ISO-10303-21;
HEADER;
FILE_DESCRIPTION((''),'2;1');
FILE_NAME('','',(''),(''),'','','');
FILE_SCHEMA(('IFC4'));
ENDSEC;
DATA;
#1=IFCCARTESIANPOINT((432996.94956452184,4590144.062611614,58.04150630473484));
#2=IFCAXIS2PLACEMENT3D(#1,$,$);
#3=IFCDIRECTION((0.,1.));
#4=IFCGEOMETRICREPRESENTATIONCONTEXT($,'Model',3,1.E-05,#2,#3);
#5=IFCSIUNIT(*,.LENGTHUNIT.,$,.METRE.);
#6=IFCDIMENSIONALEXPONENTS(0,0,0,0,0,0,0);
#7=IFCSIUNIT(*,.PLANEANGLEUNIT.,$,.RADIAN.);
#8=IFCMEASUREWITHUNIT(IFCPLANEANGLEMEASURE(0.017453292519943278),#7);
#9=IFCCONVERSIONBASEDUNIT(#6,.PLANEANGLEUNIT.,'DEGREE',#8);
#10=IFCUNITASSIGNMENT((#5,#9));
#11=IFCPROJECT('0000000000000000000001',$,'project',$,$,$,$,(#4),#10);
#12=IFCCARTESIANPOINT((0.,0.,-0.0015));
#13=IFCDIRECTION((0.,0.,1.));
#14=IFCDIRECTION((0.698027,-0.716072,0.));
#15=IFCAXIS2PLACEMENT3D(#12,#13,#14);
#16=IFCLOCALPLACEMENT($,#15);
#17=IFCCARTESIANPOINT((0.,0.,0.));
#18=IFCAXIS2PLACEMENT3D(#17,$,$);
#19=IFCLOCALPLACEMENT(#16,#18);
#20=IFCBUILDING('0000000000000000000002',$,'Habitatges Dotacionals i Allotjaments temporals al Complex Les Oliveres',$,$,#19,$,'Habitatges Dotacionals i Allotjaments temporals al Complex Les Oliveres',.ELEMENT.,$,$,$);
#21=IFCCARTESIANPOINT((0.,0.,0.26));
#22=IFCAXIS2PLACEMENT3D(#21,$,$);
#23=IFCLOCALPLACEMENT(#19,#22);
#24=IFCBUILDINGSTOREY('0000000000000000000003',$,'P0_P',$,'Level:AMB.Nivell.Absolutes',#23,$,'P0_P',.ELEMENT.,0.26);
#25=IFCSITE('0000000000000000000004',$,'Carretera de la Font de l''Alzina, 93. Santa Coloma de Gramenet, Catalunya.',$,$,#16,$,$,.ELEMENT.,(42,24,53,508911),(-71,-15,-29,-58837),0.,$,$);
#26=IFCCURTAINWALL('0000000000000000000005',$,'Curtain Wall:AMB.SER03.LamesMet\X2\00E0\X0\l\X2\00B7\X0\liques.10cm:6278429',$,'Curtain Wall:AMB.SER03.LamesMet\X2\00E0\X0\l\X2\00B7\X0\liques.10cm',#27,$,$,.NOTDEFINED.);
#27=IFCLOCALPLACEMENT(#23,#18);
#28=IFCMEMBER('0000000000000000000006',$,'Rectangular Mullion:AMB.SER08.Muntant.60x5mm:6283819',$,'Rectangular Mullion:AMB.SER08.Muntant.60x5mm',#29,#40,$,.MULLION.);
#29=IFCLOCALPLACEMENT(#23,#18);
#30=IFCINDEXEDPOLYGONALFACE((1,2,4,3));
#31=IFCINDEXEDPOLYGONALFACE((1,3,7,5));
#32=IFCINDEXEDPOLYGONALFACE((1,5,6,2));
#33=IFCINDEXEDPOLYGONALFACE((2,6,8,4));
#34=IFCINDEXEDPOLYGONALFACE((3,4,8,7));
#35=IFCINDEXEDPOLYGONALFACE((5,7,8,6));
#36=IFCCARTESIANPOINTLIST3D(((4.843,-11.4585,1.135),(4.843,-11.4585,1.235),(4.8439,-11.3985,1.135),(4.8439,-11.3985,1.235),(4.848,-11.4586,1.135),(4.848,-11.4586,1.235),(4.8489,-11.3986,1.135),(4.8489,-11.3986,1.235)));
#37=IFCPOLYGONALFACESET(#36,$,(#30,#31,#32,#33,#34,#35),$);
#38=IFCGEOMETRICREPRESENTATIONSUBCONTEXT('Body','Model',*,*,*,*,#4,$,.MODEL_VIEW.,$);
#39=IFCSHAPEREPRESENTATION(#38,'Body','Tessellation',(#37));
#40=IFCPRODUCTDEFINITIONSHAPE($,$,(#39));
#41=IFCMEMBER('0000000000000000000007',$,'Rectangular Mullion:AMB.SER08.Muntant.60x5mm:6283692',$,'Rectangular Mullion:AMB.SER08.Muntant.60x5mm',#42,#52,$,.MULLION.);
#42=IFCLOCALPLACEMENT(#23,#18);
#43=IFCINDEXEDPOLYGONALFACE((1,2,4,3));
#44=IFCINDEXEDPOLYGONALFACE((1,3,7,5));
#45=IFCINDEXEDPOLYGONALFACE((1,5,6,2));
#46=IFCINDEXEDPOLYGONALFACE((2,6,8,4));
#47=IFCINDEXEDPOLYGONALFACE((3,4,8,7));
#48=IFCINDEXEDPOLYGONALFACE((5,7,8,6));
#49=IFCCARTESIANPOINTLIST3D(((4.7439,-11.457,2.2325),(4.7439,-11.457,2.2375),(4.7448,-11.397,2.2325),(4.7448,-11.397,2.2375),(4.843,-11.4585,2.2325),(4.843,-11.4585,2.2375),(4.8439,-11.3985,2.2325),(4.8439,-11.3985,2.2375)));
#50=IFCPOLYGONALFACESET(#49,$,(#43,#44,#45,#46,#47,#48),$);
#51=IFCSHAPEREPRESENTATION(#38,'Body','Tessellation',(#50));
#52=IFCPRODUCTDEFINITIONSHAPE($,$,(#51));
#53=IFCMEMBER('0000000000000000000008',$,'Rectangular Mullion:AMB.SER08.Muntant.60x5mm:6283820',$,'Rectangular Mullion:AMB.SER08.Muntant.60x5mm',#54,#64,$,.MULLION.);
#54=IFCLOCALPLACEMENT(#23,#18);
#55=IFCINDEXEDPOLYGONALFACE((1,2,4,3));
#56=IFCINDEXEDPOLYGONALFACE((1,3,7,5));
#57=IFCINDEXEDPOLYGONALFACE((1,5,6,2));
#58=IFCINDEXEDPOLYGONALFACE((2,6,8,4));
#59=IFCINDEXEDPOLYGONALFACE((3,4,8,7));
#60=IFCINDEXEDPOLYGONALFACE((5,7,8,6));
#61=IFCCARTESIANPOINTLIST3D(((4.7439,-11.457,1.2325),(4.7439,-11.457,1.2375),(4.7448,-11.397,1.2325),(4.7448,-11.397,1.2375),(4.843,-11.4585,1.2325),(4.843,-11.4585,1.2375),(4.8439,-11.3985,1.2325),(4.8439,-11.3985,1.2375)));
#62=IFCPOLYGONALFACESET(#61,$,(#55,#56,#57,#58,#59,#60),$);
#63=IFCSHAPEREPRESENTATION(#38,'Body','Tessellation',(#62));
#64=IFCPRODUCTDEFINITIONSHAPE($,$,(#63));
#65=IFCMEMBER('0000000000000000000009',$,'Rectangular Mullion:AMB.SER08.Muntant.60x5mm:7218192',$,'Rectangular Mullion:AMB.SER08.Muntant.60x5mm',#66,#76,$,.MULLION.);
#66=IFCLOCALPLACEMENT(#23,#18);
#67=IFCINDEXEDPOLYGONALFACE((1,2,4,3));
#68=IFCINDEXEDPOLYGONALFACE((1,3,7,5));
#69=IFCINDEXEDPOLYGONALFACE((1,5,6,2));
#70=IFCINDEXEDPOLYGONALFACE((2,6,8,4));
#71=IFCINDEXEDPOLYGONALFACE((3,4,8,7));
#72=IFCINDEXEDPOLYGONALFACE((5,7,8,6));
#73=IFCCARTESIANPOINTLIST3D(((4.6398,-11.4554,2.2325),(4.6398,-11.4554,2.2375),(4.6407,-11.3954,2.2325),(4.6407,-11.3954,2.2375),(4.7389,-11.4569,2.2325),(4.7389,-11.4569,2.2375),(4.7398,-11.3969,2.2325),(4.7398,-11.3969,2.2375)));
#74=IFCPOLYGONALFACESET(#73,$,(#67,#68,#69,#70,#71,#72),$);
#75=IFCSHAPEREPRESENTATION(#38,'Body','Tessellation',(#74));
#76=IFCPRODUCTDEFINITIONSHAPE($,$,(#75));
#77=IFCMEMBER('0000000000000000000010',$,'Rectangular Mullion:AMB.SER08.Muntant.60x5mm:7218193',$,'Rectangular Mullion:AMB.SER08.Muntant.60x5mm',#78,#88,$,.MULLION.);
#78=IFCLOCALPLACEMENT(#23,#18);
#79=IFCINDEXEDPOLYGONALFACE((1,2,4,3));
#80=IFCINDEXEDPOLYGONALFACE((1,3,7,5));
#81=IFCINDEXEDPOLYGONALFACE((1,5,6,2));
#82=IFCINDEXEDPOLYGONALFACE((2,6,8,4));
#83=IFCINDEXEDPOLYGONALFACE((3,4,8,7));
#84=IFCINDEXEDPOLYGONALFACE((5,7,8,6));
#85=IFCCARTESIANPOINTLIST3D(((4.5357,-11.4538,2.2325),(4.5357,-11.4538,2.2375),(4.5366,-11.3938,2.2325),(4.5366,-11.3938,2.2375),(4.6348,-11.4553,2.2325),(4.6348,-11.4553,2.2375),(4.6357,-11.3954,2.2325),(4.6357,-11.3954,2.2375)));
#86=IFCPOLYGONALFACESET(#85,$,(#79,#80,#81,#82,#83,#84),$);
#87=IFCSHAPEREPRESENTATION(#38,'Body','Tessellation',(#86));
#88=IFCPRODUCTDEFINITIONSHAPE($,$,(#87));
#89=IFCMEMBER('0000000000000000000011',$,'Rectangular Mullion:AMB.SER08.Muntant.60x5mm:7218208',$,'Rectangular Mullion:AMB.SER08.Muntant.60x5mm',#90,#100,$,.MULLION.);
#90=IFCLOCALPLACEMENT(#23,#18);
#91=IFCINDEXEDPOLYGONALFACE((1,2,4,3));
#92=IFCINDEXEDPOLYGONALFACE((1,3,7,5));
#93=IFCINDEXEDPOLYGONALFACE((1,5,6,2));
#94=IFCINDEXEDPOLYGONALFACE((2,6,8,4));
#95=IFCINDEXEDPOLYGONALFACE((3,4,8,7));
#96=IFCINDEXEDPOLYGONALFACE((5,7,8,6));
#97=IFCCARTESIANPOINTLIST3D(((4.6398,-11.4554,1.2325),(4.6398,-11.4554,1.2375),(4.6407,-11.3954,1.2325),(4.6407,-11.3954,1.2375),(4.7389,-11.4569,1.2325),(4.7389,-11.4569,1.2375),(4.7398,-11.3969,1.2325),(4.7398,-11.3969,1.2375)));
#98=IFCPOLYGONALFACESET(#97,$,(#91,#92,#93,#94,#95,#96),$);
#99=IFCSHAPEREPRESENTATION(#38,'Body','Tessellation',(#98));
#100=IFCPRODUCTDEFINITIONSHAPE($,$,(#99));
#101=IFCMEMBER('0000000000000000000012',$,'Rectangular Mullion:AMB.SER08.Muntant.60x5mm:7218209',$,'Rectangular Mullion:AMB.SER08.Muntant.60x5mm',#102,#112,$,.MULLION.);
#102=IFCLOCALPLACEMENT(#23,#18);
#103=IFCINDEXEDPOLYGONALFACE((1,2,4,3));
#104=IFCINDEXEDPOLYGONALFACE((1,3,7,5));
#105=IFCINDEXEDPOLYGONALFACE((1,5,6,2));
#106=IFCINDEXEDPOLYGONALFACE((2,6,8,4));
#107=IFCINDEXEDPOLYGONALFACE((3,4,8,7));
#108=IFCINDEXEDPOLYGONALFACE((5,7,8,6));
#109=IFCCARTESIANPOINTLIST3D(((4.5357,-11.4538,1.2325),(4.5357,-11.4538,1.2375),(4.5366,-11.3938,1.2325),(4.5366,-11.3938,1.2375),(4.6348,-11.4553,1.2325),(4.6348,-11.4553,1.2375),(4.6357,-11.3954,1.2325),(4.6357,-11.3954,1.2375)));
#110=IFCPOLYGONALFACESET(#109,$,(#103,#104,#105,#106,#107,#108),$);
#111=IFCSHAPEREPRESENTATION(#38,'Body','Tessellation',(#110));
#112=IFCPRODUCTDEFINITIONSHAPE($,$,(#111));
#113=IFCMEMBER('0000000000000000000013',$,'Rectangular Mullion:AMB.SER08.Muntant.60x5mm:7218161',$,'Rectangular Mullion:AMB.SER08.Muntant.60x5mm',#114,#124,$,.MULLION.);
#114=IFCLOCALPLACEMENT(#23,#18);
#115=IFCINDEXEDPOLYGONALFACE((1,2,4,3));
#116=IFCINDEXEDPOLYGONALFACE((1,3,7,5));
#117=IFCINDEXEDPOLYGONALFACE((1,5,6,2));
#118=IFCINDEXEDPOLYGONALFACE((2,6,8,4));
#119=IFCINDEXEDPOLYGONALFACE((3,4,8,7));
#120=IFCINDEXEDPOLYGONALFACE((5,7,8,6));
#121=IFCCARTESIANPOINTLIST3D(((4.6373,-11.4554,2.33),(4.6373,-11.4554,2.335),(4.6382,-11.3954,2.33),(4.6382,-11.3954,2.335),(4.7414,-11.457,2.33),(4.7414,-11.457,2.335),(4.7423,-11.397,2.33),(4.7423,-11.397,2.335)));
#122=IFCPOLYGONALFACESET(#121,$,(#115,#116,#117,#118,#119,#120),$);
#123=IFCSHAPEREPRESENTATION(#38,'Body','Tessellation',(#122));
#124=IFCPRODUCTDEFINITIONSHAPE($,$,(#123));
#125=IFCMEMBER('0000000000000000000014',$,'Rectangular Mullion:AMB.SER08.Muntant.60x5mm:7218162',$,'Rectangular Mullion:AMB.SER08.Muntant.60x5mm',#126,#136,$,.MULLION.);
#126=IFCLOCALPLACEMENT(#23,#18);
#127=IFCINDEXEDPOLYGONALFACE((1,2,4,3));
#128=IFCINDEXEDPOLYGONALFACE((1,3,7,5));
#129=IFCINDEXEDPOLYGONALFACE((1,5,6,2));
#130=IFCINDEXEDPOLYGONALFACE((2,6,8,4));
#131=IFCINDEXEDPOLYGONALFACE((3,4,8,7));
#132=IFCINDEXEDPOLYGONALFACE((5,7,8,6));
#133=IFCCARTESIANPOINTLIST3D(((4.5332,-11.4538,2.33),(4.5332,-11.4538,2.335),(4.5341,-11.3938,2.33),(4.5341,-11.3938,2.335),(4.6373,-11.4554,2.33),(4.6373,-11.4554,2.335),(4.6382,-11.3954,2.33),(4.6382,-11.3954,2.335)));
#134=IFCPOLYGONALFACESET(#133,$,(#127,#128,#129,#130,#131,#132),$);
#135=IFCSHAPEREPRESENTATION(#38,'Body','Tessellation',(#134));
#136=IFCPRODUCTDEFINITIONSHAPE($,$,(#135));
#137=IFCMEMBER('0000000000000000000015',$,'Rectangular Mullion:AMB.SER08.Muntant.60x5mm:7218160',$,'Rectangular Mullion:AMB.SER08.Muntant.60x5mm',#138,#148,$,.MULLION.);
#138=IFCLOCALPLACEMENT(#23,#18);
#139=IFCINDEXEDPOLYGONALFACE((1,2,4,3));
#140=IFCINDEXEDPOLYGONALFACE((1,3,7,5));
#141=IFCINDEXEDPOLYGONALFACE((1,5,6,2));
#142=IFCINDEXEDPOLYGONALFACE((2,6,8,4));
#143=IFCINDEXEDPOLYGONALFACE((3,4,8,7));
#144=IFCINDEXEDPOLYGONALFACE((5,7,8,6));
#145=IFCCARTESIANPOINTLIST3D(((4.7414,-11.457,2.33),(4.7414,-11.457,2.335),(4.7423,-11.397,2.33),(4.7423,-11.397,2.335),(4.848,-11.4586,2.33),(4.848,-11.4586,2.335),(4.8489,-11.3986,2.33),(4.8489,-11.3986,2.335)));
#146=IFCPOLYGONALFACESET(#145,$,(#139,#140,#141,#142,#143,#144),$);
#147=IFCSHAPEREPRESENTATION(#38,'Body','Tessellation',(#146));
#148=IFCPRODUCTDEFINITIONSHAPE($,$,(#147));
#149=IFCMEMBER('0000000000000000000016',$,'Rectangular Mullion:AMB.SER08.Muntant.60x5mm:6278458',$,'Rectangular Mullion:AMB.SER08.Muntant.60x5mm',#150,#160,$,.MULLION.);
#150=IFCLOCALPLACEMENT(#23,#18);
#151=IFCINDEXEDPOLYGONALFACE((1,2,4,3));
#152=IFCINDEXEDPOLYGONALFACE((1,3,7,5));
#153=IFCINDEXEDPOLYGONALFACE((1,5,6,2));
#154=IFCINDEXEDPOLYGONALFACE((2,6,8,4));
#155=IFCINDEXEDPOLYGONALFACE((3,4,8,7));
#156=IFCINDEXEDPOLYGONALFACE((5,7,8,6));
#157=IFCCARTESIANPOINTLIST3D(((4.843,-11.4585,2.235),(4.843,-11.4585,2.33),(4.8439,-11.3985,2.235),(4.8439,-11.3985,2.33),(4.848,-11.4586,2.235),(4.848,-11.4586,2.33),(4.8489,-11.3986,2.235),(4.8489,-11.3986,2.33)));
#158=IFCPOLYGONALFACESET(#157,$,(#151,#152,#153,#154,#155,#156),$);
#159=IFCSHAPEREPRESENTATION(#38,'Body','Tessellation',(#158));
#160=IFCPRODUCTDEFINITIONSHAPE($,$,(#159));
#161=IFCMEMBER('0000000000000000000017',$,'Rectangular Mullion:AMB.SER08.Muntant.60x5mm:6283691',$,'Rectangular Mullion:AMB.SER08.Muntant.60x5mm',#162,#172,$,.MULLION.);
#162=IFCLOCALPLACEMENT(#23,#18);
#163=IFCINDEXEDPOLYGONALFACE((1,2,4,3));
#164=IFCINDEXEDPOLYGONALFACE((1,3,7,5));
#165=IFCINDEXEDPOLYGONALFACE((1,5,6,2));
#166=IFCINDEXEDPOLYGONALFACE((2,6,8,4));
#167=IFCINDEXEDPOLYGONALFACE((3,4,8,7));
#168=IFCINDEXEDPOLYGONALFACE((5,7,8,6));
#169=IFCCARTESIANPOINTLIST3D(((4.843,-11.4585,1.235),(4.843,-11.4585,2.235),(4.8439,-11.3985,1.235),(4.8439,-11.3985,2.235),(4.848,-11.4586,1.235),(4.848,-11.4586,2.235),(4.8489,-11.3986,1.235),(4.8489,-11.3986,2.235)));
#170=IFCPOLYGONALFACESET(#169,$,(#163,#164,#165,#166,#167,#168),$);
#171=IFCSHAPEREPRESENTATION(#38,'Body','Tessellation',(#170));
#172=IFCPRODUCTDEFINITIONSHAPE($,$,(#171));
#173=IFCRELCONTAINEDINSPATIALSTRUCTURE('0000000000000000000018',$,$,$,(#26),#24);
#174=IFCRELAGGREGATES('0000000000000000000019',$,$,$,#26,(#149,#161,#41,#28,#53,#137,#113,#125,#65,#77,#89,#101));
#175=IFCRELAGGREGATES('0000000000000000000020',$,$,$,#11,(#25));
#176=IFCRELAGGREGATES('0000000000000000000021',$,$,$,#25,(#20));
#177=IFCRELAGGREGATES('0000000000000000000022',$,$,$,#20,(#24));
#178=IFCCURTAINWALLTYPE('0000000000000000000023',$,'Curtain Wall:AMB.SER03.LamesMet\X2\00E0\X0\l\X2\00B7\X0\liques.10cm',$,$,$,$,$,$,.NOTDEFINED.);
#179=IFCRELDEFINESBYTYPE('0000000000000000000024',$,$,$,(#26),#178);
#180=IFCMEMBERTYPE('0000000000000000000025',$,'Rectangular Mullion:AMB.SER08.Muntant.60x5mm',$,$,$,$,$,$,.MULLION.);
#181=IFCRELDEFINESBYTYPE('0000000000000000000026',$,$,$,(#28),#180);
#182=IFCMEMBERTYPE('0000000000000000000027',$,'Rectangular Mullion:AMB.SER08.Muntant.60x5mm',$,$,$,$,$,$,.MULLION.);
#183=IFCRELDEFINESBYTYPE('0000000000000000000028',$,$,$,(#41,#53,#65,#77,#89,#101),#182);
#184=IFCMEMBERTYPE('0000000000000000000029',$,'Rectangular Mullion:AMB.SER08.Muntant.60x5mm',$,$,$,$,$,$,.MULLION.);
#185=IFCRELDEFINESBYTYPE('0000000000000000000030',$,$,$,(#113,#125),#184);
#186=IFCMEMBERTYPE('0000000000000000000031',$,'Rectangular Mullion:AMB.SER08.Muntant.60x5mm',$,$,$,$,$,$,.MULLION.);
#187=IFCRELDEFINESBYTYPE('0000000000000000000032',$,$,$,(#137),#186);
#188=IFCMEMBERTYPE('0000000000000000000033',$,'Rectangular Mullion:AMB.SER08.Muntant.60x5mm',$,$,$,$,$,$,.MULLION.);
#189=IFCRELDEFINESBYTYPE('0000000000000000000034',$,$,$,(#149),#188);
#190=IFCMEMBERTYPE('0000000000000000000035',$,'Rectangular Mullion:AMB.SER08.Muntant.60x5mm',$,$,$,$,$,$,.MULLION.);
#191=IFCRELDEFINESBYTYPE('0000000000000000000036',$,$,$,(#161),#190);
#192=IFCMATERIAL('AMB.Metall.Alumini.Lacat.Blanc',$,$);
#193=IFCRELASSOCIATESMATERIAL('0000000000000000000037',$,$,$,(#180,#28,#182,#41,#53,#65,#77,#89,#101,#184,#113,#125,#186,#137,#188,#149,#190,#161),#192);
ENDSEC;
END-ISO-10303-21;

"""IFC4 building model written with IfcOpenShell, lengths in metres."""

from ifc_helpers import new_model, entity, si_unit, converted_unit, direction, frame, origin, place, context, subcontext, project, spatial, indexed_curve, outline, extrude, source, transform, mapped, material, type_object, type_shapes, element, aggregate, save


model = new_model("IFC4")

# Units and contexts
model_context = context("Model", 3, precision=1e-05, world=frame((432996.94956452184, 4590144.062611614, 58.04150630473484)), true_north=direction((0.0, 1.0)))
body_context = subcontext(model_context, "Body", "Model", "MODEL_VIEW")
ifc_project = project(units=[si_unit("LENGTHUNIT", "METRE"), converted_unit("PLANEANGLEUNIT", "DEGREE", entity("IfcPlaneAngleMeasure", 0.017453292519943278), si_unit("PLANEANGLEUNIT", "RADIAN"), dimensions=[0, 0, 0, 0, 0, 0, 0])], contexts=[model_context])

# Site, building, storey
site_placement = place(None, frame((0.0, 0.0, -0.0015), z_axis=(0.0, 0.0, 1.0), x_axis=(0.698027, -0.716072, 0.0)))
site = spatial("IfcSite", under=ifc_project, at=site_placement, Name="Carretera de la Font de l'Alzina, 93. Santa Coloma de Gramenet, Catalunya.", CompositionType="ELEMENT", RefLatitude=(42, 24, 53, 508911), RefLongitude=(-71, -15, -29, -58837), RefElevation=0.0)
building_placement = place(site_placement, origin())
building = spatial("IfcBuilding", under=site, at=building_placement, Name="Habitatges Dotacionals i Allotjaments temporals al Complex Les Oliveres", LongName="Habitatges Dotacionals i Allotjaments temporals al Complex Les Oliveres", CompositionType="ELEMENT")
storey_placement = place(building_placement, frame((0.0, 0.0, 0.26)))
storey = spatial("IfcBuildingStorey", under=building, at=storey_placement, Name="P0_P", ObjectType="Level:AMB.Nivell.Absolutes", LongName="P0_P", CompositionType="ELEMENT", Elevation=0.26)

# Curtain wall, members
curtain_wall_type_1 = type_object("IfcCurtainWallType", Name="Curtain Wall:AMB.SER03.LamesMetàl·liques.10cm", PredefinedType="NOTDEFINED")
curtain_wall_1_placement = place(storey_placement, frame((0.0, 0.0, -0.26)))
curtain_wall_1 = element("IfcCurtainWall", 1, at=curtain_wall_1_placement, inside=storey, type_object=curtain_wall_type_1, Name="Curtain Wall:AMB.SER03.LamesMetàl·liques.10cm:6278429", ObjectType="Curtain Wall:AMB.SER03.LamesMetàl·liques.10cm", PredefinedType="NOTDEFINED")
ifc_material_1 = material(Name="AMB.Metall.Alumini.Lacat.Blanc")
member_type_1 = type_object("IfcMemberType", Name="Rectangular Mullion:AMB.SER08.Muntant.60x5mm", PredefinedType="MULLION", material=ifc_material_1)
shared_shape_1 = source(origin(), body_context, "Body", "SweptSolid", [
    extrude(outline(indexed_curve([(-0.0025, -0.03), (0.0025, -0.03), (0.0025, 0.03), (-0.0025, 0.03), (-0.0025, -0.03)], self_intersect=False)), frame((-0.0025, 0.03, -0.1), z_axis=(0.0, 0.0, 1.0), x_axis=(-1.0, 0.0, 0.0)), (0.0, 0.0, 1.0), 0.1),
])
type_shapes(member_type_1, [shared_shape_1])
member_1_placement = place(curtain_wall_1_placement, frame((4.848, -11.4586, 1.495), z_axis=(0.0, 0.0, 1.0), x_axis=(0.999883, -0.015319, 0.0)))
member_1 = element("IfcMember", 2, at=member_1_placement, type_object=member_type_1, material=ifc_material_1, Name="Rectangular Mullion:AMB.SER08.Muntant.60x5mm:6283819", ObjectType="Rectangular Mullion:AMB.SER08.Muntant.60x5mm", PredefinedType="MULLION", context=body_context, shape_type="MappedRepresentation", body=[
    mapped(shared_shape_1, transform((0.0, 0.0, 0.0), scale=1.0)),
])
member_type_2 = type_object("IfcMemberType", Name="Rectangular Mullion:AMB.SER08.Muntant.60x5mm", PredefinedType="MULLION", material=ifc_material_1)
shared_shape_2 = source(origin(), body_context, "Body", "SweptSolid", [
    extrude(outline(indexed_curve([(-0.0025, -0.03), (0.0025, -0.03), (0.0025, 0.03), (-0.0025, 0.03), (-0.0025, -0.03)], self_intersect=False)), frame((0.0, 0.03, -0.0991), z_axis=(0.0, 0.0, 1.0), x_axis=(-1.0, 0.0, 0.0)), (0.0, 0.0, 1.0), 0.0991),
])
type_shapes(member_type_2, [shared_shape_2])
member_2_placement = place(curtain_wall_1_placement, frame((4.7439, -11.457, 2.495), z_axis=(-0.999883, 0.015319, 0.0), x_axis=(0.0, 0.0, 1.0)))
member_2 = element("IfcMember", 3, at=member_2_placement, type_object=member_type_2, material=ifc_material_1, Name="Rectangular Mullion:AMB.SER08.Muntant.60x5mm:6283692", ObjectType="Rectangular Mullion:AMB.SER08.Muntant.60x5mm", PredefinedType="MULLION", context=body_context, shape_type="MappedRepresentation", body=[
    mapped(shared_shape_2, transform((0.0, 0.0, 0.0), scale=1.0)),
])
member_3_placement = place(curtain_wall_1_placement, frame((4.7439, -11.457, 1.495), z_axis=(-0.999883, 0.015319, 0.0), x_axis=(0.0, 0.0, 1.0)))
member_3 = element("IfcMember", 4, at=member_3_placement, type_object=member_type_2, material=ifc_material_1, Name="Rectangular Mullion:AMB.SER08.Muntant.60x5mm:6283820", ObjectType="Rectangular Mullion:AMB.SER08.Muntant.60x5mm", PredefinedType="MULLION", context=body_context, shape_type="MappedRepresentation", body=[
    mapped(shared_shape_2, transform((0.0, 0.0, 0.0), scale=1.0)),
])
member_4_placement = place(curtain_wall_1_placement, frame((4.6398, -11.4554, 2.495), z_axis=(-0.999883, 0.015319, 0.0), x_axis=(0.0, 0.0, 1.0)))
member_4 = element("IfcMember", 5, at=member_4_placement, type_object=member_type_2, material=ifc_material_1, Name="Rectangular Mullion:AMB.SER08.Muntant.60x5mm:7218192", ObjectType="Rectangular Mullion:AMB.SER08.Muntant.60x5mm", PredefinedType="MULLION", context=body_context, shape_type="MappedRepresentation", body=[
    mapped(shared_shape_2, transform((0.0, 0.0, 0.0), scale=1.0)),
])
member_5_placement = place(curtain_wall_1_placement, frame((4.5357, -11.4538, 2.495), z_axis=(-0.999883, 0.015319, 0.0), x_axis=(0.0, 0.0, 1.0)))
member_5 = element("IfcMember", 6, at=member_5_placement, type_object=member_type_2, material=ifc_material_1, Name="Rectangular Mullion:AMB.SER08.Muntant.60x5mm:7218193", ObjectType="Rectangular Mullion:AMB.SER08.Muntant.60x5mm", PredefinedType="MULLION", context=body_context, shape_type="MappedRepresentation", body=[
    mapped(shared_shape_2, transform((0.0, 0.0, 0.0), scale=1.0)),
])
member_6_placement = place(curtain_wall_1_placement, frame((4.6398, -11.4554, 1.495), z_axis=(-0.999883, 0.015319, 0.0), x_axis=(0.0, 0.0, 1.0)))
member_6 = element("IfcMember", 7, at=member_6_placement, type_object=member_type_2, material=ifc_material_1, Name="Rectangular Mullion:AMB.SER08.Muntant.60x5mm:7218208", ObjectType="Rectangular Mullion:AMB.SER08.Muntant.60x5mm", PredefinedType="MULLION", context=body_context, shape_type="MappedRepresentation", body=[
    mapped(shared_shape_2, transform((0.0, 0.0, 0.0), scale=1.0)),
])
member_7_placement = place(curtain_wall_1_placement, frame((4.5357, -11.4538, 1.495), z_axis=(-0.999883, 0.015319, 0.0), x_axis=(0.0, 0.0, 1.0)))
member_7 = element("IfcMember", 8, at=member_7_placement, type_object=member_type_2, material=ifc_material_1, Name="Rectangular Mullion:AMB.SER08.Muntant.60x5mm:7218209", ObjectType="Rectangular Mullion:AMB.SER08.Muntant.60x5mm", PredefinedType="MULLION", context=body_context, shape_type="MappedRepresentation", body=[
    mapped(shared_shape_2, transform((0.0, 0.0, 0.0), scale=1.0)),
])
member_type_3 = type_object("IfcMemberType", Name="Rectangular Mullion:AMB.SER08.Muntant.60x5mm", PredefinedType="MULLION", material=ifc_material_1)
shared_shape_3 = source(origin(), body_context, "Body", "SweptSolid", [
    extrude(outline(indexed_curve([(-0.0025, -0.03), (0.0025, -0.03), (0.0025, 0.03), (-0.0025, 0.03), (-0.0025, -0.03)], self_intersect=False)), frame((-0.0025, 0.03, -0.1041), z_axis=(0.0, 0.0, 1.0), x_axis=(-1.0, 0.0, 0.0)), (0.0, 0.0, 1.0), 0.1041),
])
type_shapes(member_type_3, [shared_shape_3])
member_8_placement = place(curtain_wall_1_placement, frame((4.6373, -11.4554, 2.595), z_axis=(-0.999883, 0.015319, 0.0), x_axis=(0.0, 0.0, 1.0)))
member_8 = element("IfcMember", 9, at=member_8_placement, type_object=member_type_3, material=ifc_material_1, Name="Rectangular Mullion:AMB.SER08.Muntant.60x5mm:7218161", ObjectType="Rectangular Mullion:AMB.SER08.Muntant.60x5mm", PredefinedType="MULLION", context=body_context, shape_type="MappedRepresentation", body=[
    mapped(shared_shape_3, transform((0.0, 0.0, 0.0), scale=1.0)),
])
member_9_placement = place(curtain_wall_1_placement, frame((4.5332, -11.4538, 2.595), z_axis=(-0.999883, 0.015319, 0.0), x_axis=(0.0, 0.0, 1.0)))
member_9 = element("IfcMember", 10, at=member_9_placement, type_object=member_type_3, material=ifc_material_1, Name="Rectangular Mullion:AMB.SER08.Muntant.60x5mm:7218162", ObjectType="Rectangular Mullion:AMB.SER08.Muntant.60x5mm", PredefinedType="MULLION", context=body_context, shape_type="MappedRepresentation", body=[
    mapped(shared_shape_3, transform((0.0, 0.0, 0.0), scale=1.0)),
])
member_type_4 = type_object("IfcMemberType", Name="Rectangular Mullion:AMB.SER08.Muntant.60x5mm", PredefinedType="MULLION", material=ifc_material_1)
shared_shape_4 = source(origin(), body_context, "Body", "SweptSolid", [
    extrude(outline(indexed_curve([(-0.0025, -0.03), (0.0025, -0.03), (0.0025, 0.03), (-0.0025, 0.03), (-0.0025, -0.03)], self_intersect=False)), frame((-0.0025, 0.03, -0.1066), z_axis=(0.0, 0.0, 1.0), x_axis=(-1.0, 0.0, 0.0)), (0.0, 0.0, 1.0), 0.1066),
])
type_shapes(member_type_4, [shared_shape_4])
member_10_placement = place(curtain_wall_1_placement, frame((4.7414, -11.457, 2.595), z_axis=(-0.999883, 0.015319, 0.0), x_axis=(0.0, 0.0, 1.0)))
member_10 = element("IfcMember", 11, at=member_10_placement, type_object=member_type_4, material=ifc_material_1, Name="Rectangular Mullion:AMB.SER08.Muntant.60x5mm:7218160", ObjectType="Rectangular Mullion:AMB.SER08.Muntant.60x5mm", PredefinedType="MULLION", context=body_context, shape_type="MappedRepresentation", body=[
    mapped(shared_shape_4, transform((0.0, 0.0, 0.0), scale=1.0)),
])
member_type_5 = type_object("IfcMemberType", Name="Rectangular Mullion:AMB.SER08.Muntant.60x5mm", PredefinedType="MULLION", material=ifc_material_1)
shared_shape_5 = source(origin(), body_context, "Body", "SweptSolid", [
    extrude(outline(indexed_curve([(-0.0025, -0.03), (0.0025, -0.03), (0.0025, 0.03), (-0.0025, 0.03), (-0.0025, -0.03)], self_intersect=False)), frame((-0.0025, 0.03, -0.095), z_axis=(0.0, 0.0, 1.0), x_axis=(-1.0, 0.0, 0.0)), (0.0, 0.0, 1.0), 0.095),
])
type_shapes(member_type_5, [shared_shape_5])
member_11_placement = place(curtain_wall_1_placement, frame((4.848, -11.4586, 2.59), z_axis=(0.0, 0.0, 1.0), x_axis=(0.999883, -0.015319, 0.0)))
member_11 = element("IfcMember", 12, at=member_11_placement, type_object=member_type_5, material=ifc_material_1, Name="Rectangular Mullion:AMB.SER08.Muntant.60x5mm:6278458", ObjectType="Rectangular Mullion:AMB.SER08.Muntant.60x5mm", PredefinedType="MULLION", context=body_context, shape_type="MappedRepresentation", body=[
    mapped(shared_shape_5, transform((0.0, 0.0, 0.0), scale=1.0)),
])
member_type_6 = type_object("IfcMemberType", Name="Rectangular Mullion:AMB.SER08.Muntant.60x5mm", PredefinedType="MULLION", material=ifc_material_1)
shared_shape_6 = source(origin(), body_context, "Body", "SweptSolid", [
    extrude(outline(indexed_curve([(-0.0025, -0.03), (0.0025, -0.03), (0.0025, 0.03), (-0.0025, 0.03), (-0.0025, -0.03)], self_intersect=False)), frame((-0.0025, 0.03, -1.0), z_axis=(0.0, 0.0, 1.0), x_axis=(-1.0, 0.0, 0.0)), (0.0, 0.0, 1.0), 1.0),
])
type_shapes(member_type_6, [shared_shape_6])
member_12_placement = place(curtain_wall_1_placement, frame((4.848, -11.4586, 2.495), z_axis=(0.0, 0.0, 1.0), x_axis=(0.999883, -0.015319, 0.0)))
member_12 = element("IfcMember", 13, at=member_12_placement, type_object=member_type_6, material=ifc_material_1, Name="Rectangular Mullion:AMB.SER08.Muntant.60x5mm:6283691", ObjectType="Rectangular Mullion:AMB.SER08.Muntant.60x5mm", PredefinedType="MULLION", context=body_context, shape_type="MappedRepresentation", body=[
    mapped(shared_shape_6, transform((0.0, 0.0, 0.0), scale=1.0)),
])
aggregate(curtain_wall_1, [member_11, member_12, member_2, member_1, member_3, member_10, member_8, member_9, member_4, member_5, member_6, member_7])

save(model, "model.ifc")
